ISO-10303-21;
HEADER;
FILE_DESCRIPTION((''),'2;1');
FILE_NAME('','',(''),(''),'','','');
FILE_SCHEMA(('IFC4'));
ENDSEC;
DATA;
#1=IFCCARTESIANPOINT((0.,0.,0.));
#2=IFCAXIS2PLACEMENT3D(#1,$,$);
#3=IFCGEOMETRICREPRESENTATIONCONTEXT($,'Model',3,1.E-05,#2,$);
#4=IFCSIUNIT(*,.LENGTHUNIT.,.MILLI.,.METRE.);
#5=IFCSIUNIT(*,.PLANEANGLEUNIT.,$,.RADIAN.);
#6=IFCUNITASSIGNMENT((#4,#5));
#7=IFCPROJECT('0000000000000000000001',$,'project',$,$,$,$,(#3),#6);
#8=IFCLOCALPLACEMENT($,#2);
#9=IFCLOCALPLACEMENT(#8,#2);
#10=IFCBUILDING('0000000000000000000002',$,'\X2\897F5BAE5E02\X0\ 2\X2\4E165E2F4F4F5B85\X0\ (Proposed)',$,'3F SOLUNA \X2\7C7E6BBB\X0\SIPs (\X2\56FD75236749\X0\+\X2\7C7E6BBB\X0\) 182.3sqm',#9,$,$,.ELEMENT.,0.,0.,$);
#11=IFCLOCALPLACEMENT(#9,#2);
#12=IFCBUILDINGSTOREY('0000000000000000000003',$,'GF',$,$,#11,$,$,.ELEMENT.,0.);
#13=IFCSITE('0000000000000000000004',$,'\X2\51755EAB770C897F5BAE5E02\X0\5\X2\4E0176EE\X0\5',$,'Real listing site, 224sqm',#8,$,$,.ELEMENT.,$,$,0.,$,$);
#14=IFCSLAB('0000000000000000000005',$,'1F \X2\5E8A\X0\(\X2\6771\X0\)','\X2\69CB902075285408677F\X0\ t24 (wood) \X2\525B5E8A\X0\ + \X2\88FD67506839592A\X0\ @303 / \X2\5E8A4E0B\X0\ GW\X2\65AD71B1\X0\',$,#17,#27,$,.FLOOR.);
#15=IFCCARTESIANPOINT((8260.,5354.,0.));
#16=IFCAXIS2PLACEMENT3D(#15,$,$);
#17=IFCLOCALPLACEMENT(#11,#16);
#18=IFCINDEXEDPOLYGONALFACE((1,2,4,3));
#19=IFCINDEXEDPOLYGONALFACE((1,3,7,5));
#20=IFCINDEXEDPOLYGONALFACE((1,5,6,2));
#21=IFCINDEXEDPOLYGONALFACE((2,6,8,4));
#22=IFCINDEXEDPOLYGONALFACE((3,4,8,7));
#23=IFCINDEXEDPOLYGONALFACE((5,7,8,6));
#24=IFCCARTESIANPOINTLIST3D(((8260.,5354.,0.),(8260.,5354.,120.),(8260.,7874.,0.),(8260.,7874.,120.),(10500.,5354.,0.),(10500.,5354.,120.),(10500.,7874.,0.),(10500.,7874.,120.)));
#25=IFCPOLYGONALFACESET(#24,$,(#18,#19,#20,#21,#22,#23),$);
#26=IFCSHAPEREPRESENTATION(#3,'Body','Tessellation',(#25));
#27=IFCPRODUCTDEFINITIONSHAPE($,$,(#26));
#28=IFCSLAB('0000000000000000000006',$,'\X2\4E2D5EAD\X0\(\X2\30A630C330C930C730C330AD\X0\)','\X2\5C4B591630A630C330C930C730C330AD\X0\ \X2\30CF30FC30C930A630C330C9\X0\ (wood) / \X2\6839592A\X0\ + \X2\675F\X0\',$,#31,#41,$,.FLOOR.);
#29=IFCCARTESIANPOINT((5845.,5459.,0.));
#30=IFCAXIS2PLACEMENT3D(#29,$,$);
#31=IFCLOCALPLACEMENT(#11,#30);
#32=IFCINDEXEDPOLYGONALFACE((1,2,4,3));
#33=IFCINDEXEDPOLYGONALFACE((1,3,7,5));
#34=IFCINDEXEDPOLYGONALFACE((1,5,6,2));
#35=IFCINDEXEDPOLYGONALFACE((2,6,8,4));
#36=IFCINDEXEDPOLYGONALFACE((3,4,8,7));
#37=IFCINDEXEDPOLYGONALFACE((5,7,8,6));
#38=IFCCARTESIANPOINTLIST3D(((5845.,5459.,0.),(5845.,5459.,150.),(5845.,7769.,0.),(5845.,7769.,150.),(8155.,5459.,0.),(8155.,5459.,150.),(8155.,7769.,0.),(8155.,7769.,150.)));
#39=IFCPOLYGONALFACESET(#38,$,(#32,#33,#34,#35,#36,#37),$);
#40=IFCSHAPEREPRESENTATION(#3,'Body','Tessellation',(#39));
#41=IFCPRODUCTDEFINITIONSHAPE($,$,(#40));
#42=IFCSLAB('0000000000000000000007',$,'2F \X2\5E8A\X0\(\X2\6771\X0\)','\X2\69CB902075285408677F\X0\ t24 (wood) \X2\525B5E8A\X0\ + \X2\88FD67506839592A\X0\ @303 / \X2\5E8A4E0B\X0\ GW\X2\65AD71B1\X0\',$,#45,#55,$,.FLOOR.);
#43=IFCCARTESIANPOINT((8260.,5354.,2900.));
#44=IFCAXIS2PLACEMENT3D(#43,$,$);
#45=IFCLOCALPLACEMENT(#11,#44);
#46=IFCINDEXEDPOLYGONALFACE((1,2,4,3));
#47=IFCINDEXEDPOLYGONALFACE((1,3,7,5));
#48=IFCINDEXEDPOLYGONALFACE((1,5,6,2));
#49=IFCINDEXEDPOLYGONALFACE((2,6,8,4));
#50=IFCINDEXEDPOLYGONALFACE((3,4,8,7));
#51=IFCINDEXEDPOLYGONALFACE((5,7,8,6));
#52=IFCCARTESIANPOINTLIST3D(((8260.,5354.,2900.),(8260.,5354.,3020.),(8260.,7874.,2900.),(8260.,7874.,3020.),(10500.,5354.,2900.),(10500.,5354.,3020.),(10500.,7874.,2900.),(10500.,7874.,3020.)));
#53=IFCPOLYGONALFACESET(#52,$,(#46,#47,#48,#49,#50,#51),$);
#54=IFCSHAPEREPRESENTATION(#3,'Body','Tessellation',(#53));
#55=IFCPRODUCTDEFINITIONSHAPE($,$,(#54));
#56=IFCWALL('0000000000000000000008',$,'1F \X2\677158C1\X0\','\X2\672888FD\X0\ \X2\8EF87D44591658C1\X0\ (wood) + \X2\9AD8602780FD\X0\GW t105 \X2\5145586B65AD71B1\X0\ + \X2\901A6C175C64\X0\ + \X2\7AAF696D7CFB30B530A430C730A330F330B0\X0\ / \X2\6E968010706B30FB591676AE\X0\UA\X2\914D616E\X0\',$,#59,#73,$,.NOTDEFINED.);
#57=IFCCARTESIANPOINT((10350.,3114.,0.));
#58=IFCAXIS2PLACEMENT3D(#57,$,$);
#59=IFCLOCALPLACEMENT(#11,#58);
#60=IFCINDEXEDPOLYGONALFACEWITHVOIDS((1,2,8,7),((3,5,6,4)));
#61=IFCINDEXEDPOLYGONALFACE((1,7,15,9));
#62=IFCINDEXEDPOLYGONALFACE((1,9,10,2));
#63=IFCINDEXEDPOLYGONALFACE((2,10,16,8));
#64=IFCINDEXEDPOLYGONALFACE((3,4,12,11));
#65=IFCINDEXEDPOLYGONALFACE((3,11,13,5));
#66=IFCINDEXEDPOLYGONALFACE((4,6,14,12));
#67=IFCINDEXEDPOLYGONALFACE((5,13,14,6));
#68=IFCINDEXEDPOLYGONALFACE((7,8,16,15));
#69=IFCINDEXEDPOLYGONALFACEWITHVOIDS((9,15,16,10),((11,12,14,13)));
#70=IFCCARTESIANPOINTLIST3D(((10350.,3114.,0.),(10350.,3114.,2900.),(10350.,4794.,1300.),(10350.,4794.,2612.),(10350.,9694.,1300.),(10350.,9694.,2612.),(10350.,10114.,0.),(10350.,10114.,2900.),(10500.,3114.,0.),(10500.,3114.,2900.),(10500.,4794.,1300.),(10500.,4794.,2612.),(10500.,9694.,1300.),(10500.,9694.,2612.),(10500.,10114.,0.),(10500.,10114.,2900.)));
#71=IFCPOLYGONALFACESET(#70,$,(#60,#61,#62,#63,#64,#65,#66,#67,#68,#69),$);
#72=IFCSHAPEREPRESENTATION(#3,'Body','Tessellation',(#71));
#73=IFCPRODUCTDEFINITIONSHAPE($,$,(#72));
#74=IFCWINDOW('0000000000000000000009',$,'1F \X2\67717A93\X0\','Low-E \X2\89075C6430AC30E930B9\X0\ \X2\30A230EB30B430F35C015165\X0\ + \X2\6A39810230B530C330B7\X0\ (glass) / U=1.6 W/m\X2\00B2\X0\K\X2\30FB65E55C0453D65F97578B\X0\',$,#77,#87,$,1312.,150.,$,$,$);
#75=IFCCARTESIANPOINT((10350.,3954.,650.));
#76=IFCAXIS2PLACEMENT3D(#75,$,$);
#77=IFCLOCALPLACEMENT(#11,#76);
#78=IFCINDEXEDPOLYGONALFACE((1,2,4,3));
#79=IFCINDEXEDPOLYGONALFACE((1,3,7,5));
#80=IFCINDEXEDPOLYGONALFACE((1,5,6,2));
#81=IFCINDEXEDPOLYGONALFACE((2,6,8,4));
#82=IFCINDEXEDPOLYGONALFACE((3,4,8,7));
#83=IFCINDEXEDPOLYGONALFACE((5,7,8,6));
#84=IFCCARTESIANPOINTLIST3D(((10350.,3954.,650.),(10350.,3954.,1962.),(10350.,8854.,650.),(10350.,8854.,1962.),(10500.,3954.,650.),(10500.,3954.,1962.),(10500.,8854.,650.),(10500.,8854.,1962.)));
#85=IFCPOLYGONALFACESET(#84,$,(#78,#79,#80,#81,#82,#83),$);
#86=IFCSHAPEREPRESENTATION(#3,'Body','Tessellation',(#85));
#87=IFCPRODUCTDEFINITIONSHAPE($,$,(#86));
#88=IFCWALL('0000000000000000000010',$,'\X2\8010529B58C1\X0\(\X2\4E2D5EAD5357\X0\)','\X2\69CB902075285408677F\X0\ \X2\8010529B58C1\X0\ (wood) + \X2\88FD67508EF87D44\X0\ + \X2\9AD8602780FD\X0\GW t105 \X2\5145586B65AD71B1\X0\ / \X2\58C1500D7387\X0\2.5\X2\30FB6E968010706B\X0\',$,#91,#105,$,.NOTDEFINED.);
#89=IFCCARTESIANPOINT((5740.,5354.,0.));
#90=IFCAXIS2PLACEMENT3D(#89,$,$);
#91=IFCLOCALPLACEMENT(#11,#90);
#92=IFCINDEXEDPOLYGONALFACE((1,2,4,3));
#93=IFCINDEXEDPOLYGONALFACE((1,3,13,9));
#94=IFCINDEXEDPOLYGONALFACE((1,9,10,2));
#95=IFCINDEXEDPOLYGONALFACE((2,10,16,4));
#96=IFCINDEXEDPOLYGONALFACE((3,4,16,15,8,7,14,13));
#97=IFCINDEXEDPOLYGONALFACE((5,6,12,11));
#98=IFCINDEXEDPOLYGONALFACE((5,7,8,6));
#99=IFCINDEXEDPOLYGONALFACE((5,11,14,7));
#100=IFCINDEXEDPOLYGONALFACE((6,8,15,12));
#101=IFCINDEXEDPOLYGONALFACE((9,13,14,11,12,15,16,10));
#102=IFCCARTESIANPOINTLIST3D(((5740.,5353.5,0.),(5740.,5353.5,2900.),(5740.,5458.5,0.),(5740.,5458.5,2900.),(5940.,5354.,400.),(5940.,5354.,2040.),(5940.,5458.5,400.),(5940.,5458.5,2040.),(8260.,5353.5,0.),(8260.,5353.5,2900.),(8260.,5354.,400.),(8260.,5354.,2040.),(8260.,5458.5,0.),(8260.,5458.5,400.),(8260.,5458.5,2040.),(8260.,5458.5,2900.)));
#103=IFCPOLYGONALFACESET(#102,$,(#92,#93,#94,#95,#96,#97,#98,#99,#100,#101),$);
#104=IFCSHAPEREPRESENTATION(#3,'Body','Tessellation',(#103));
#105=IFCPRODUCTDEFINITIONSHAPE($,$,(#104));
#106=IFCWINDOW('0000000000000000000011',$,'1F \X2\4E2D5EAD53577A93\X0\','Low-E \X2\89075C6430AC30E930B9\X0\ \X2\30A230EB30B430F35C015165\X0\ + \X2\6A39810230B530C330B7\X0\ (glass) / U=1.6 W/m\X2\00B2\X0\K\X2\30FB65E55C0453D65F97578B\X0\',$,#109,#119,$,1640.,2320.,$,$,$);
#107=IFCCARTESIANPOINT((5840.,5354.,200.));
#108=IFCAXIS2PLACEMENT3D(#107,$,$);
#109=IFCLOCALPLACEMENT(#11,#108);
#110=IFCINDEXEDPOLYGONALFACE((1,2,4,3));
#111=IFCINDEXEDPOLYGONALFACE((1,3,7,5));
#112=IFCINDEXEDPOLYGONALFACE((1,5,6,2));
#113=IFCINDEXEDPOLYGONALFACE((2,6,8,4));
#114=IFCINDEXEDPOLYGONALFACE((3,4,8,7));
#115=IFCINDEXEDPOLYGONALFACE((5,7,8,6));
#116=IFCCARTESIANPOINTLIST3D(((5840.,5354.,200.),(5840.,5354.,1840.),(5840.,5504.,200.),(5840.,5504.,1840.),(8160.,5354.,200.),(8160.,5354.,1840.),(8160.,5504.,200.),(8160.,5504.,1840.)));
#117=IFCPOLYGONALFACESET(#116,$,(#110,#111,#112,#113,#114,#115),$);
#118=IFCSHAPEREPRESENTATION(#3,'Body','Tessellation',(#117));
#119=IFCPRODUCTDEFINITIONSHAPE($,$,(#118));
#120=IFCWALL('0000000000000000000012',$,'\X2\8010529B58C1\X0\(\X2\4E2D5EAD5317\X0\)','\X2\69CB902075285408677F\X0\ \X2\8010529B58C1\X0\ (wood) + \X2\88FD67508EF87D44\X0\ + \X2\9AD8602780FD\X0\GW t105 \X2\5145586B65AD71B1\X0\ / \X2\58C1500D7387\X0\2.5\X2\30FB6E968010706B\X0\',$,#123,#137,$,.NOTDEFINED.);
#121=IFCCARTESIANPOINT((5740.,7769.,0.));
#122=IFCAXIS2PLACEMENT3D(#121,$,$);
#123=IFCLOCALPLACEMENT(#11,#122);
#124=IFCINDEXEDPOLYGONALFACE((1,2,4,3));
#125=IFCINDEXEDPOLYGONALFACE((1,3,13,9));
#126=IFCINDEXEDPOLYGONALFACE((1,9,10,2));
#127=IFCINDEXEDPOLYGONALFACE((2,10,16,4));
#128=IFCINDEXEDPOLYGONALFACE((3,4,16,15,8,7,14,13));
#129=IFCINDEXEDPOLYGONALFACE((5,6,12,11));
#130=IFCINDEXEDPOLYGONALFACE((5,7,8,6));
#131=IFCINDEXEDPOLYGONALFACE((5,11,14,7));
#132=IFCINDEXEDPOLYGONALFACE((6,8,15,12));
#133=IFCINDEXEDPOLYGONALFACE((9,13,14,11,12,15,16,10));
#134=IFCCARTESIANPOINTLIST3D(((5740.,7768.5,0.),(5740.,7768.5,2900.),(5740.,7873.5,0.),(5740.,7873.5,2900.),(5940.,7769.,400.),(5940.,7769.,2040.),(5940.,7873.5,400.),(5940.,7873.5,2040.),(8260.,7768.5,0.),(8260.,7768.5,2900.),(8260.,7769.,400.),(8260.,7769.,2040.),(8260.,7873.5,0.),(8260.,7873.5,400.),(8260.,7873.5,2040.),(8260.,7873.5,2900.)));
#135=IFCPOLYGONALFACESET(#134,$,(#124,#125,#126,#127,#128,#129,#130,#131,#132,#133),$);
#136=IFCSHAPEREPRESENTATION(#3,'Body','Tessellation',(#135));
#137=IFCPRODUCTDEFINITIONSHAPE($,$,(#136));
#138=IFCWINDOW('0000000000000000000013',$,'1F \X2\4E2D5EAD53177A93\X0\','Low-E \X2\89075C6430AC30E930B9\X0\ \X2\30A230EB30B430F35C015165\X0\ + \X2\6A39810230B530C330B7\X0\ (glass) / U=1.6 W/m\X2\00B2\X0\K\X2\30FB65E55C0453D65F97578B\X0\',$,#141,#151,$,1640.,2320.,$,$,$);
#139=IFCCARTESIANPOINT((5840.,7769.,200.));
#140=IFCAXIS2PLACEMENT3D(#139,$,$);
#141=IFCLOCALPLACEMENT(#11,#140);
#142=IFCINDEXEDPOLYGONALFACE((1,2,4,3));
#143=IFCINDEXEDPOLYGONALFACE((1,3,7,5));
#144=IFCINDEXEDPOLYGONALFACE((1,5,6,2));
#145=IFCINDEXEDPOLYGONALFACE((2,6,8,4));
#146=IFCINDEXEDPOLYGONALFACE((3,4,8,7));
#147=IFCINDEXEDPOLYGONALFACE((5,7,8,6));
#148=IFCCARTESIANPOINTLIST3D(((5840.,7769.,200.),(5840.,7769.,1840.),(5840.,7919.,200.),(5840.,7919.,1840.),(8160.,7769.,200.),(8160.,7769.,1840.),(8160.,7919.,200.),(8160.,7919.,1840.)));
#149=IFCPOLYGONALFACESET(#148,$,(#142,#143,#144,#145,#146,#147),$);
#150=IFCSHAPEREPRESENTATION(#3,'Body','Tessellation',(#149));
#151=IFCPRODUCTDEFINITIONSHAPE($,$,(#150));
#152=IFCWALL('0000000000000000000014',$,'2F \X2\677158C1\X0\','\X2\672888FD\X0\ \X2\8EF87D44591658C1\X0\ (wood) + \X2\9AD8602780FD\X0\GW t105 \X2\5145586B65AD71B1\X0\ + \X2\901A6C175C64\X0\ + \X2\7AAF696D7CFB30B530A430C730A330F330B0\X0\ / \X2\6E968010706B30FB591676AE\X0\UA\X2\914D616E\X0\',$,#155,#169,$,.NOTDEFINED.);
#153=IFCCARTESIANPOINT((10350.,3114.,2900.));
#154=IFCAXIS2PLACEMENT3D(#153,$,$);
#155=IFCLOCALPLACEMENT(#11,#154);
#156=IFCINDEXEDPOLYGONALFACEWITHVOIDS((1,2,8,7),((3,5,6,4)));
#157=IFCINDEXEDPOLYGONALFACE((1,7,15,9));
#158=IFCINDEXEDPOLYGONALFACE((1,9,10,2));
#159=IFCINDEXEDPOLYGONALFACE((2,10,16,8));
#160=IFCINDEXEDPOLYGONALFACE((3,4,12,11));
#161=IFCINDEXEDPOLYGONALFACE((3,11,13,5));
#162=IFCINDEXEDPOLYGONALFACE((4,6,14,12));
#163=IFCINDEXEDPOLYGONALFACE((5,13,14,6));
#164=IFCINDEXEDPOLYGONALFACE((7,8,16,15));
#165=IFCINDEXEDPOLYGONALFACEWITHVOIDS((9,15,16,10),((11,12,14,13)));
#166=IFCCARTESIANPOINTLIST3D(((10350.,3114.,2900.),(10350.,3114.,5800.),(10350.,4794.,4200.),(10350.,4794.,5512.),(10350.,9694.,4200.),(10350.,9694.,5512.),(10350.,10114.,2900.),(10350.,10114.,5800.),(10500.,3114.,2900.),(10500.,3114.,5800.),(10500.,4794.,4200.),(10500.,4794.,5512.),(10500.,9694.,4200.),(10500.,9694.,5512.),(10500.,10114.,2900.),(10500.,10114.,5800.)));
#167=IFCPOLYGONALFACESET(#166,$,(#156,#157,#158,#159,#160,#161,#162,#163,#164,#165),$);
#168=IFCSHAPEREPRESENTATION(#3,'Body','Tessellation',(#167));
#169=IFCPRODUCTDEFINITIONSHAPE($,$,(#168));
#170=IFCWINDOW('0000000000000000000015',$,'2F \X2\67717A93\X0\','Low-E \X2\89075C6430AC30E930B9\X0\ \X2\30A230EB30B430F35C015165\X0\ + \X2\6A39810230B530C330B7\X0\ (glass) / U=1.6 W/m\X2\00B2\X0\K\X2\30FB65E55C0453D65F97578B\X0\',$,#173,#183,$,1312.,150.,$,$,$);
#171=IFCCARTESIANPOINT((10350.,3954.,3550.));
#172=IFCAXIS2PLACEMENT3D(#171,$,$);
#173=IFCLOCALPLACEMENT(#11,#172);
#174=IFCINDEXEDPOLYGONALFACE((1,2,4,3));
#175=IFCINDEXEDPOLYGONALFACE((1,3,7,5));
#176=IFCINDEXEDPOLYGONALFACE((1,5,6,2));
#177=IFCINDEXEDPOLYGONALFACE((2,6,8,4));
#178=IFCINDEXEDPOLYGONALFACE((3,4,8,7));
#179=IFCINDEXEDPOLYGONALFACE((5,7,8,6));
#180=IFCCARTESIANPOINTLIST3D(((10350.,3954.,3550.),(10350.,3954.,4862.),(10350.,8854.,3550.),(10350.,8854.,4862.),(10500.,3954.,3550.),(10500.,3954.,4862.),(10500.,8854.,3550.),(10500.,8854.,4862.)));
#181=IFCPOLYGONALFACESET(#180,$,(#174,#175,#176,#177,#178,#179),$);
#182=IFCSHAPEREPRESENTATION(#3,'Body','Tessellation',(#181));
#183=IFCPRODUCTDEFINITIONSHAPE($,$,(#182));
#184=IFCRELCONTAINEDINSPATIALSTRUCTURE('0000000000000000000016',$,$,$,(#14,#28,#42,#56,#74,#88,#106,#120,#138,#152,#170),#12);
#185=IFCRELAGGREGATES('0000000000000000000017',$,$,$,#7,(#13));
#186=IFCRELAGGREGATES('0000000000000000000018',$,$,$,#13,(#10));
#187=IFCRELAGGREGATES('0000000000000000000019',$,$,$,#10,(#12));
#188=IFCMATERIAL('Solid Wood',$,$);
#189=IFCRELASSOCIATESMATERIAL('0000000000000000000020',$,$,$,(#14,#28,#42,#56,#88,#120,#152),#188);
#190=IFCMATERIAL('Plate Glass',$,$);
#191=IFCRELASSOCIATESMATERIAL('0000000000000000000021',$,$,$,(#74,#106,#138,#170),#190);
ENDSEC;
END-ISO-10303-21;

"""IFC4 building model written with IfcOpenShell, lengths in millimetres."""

from ifc_helpers import new_model, si_unit, frame, frame_2d, origin, place, context, project, spatial, rectangle, extrude, material, element, fill, save


model = new_model("IFC4")

# Units and contexts
model_context = context("Model", 3, precision=1e-05, world=origin())
ifc_project = project(units=[si_unit("LENGTHUNIT", "METRE", prefix="MILLI"), si_unit("PLANEANGLEUNIT", "RADIAN")], contexts=[model_context])

# Site, building, storey
site_placement = place(None, origin())
site = spatial("IfcSite", under=ifc_project, at=site_placement, Name="兵庫県西宮市5丁目5", ObjectType="Real listing site, 224sqm", CompositionType="ELEMENT", RefElevation=0.0)
building_placement = place(site_placement, origin())
building = spatial("IfcBuilding", under=site, at=building_placement, Name="西宮市 2世帯住宅 (Proposed)", ObjectType="3F SOLUNA 籾殻SIPs (国産杉+籾殻) 182.3sqm", CompositionType="ELEMENT", ElevationOfRefHeight=0.0, ElevationOfTerrain=0.0)
storey_placement = place(building_placement, origin())
storey = spatial("IfcBuildingStorey", under=building, at=storey_placement, Name="GF", CompositionType="ELEMENT", Elevation=0.0)

# Slabs
ifc_material_1 = material(Name="Solid Wood")
slab_1_placement = place(storey_placement, frame((8260.0, 5354.0, 0.0)))
element("IfcSlab", 1, at=slab_1_placement, inside=storey, material=ifc_material_1, Name="1F 床(東)", Description="構造用合板 t24 (wood) 剛床 + 製材根太 @303 / 床下 GW断熱", PredefinedType="FLOOR", context=model_context, shape_type="SweptSolid", body=[
    extrude(rectangle(XDim=2240.0, YDim=2520.0, at=frame_2d((1120.0, 1260.0))), frame((8260.0, 5354.0, 0.0)), (0.0, 0.0, 1.0), 120.0),
])
slab_2_placement = place(storey_placement, frame((5845.0, 5459.0, 0.0)))
element("IfcSlab", 2, at=slab_2_placement, inside=storey, material=ifc_material_1, Name="中庭(ウッドデッキ)", Description="屋外ウッドデッキ ハードウッド (wood) / 根太 + 束", PredefinedType="FLOOR", context=model_context, shape_type="SweptSolid", body=[
    extrude(rectangle(XDim=2310.0, YDim=2310.0, at=frame_2d((1155.0, 1155.0))), frame((5845.0, 5459.0, 0.0)), (0.0, 0.0, 1.0), 150.0),
])
slab_3_placement = place(storey_placement, frame((8260.0, 5354.0, 2900.0)))
element("IfcSlab", 3, at=slab_3_placement, inside=storey, material=ifc_material_1, Name="2F 床(東)", Description="構造用合板 t24 (wood) 剛床 + 製材根太 @303 / 床下 GW断熱", PredefinedType="FLOOR", context=model_context, shape_type="SweptSolid", body=[
    extrude(rectangle(XDim=2240.0, YDim=2520.0, at=frame_2d((1120.0, 1260.0))), frame((8260.0, 5354.0, 2900.0)), (0.0, 0.0, 1.0), 120.0),
])

# Walls, openings, windows
wall_1_placement = place(storey_placement, frame((10350.0, 3114.0, 0.0)))
wall_1 = element("IfcWall", 4, at=wall_1_placement, inside=storey, material=ifc_material_1, Name="1F 東壁", Description="木製 軸組外壁 (wood) + 高性能GW t105 充填断熱 + 通気層 + 窯業系サイディング / 準耐火・外皮UA配慮", PredefinedType="NOTDEFINED", context=model_context, shape_type="SweptSolid", body=[
    extrude(rectangle(XDim=150.0, YDim=7000.0, at=frame_2d((75.0, 3500.0))), frame((10350.0, 3114.0, 0.0)), (0.0, 0.0, 1.0), 2900.0),
])
opening_1_placement = place(storey_placement, frame((10350.0, 3954.0, 650.0)))
opening_1 = element("IfcOpeningElement", 5, at=opening_1_placement, cuts=wall_1, PredefinedType="NOTDEFINED", context=model_context, shape_type="SweptSolid", body=[
    extrude(rectangle(XDim=150.0, YDim=4900.0, at=frame_2d((75.0, 2450.0))), frame((10350.0, 3954.0, 650.0)), (0.0, 0.0, 1.0), 1312.0),
])
ifc_material_2 = material(Name="Plate Glass")
window_1_placement = place(storey_placement, frame((10350.0, 3954.0, 650.0)))
window_1 = element("IfcWindow", 6, at=window_1_placement, inside=storey, material=ifc_material_2, Name="1F 東窓", Description="Low-E 複層ガラス アルゴン封入 + 樹脂サッシ (glass) / U=1.6 W/m²K・日射取得型", OverallHeight=1312.0, OverallWidth=150.0, context=model_context, shape_type="SweptSolid", body=[
    extrude(rectangle(XDim=150.0, YDim=4900.0, at=frame_2d((75.0, 2450.0))), frame((10350.0, 3954.0, 650.0)), (0.0, 0.0, 1.0), 1312.0),
])
fill(opening_1, window_1)
wall_2_placement = place(storey_placement, frame((5740.0, 5354.0, 0.0)))
wall_2 = element("IfcWall", 7, at=wall_2_placement, inside=storey, material=ifc_material_1, Name="耐力壁(中庭南)", Description="構造用合板 耐力壁 (wood) + 製材軸組 + 高性能GW t105 充填断熱 / 壁倍率2.5・準耐火", PredefinedType="NOTDEFINED", context=model_context, shape_type="SweptSolid", body=[
    extrude(rectangle(XDim=2520.0, YDim=105.0, at=frame_2d((1260.0, 52.0))), frame((5740.0, 5354.0, 0.0)), (0.0, 0.0, 1.0), 2900.0),
])
opening_2_placement = place(storey_placement, frame((5840.0, 5354.0, 200.0)))
opening_2 = element("IfcOpeningElement", 8, at=opening_2_placement, cuts=wall_2, PredefinedType="NOTDEFINED", context=model_context, shape_type="SweptSolid", body=[
    extrude(rectangle(XDim=2320.0, YDim=150.0, at=frame_2d((1160.0, 75.0))), frame((5840.0, 5354.0, 200.0)), (0.0, 0.0, 1.0), 1640.0),
])
window_2_placement = place(storey_placement, frame((5840.0, 5354.0, 200.0)))
window_2 = element("IfcWindow", 9, at=window_2_placement, inside=storey, material=ifc_material_2, Name="1F 中庭南窓", Description="Low-E 複層ガラス アルゴン封入 + 樹脂サッシ (glass) / U=1.6 W/m²K・日射取得型", OverallHeight=1640.0, OverallWidth=2320.0, context=model_context, shape_type="SweptSolid", body=[
    extrude(rectangle(XDim=2320.0, YDim=150.0, at=frame_2d((1160.0, 75.0))), frame((5840.0, 5354.0, 200.0)), (0.0, 0.0, 1.0), 1640.0),
])
fill(opening_2, window_2)
wall_3_placement = place(storey_placement, frame((5740.0, 7769.0, 0.0)))
wall_3 = element("IfcWall", 10, at=wall_3_placement, inside=storey, material=ifc_material_1, Name="耐力壁(中庭北)", Description="構造用合板 耐力壁 (wood) + 製材軸組 + 高性能GW t105 充填断熱 / 壁倍率2.5・準耐火", PredefinedType="NOTDEFINED", context=model_context, shape_type="SweptSolid", body=[
    extrude(rectangle(XDim=2520.0, YDim=105.0, at=frame_2d((1260.0, 52.0))), frame((5740.0, 7769.0, 0.0)), (0.0, 0.0, 1.0), 2900.0),
])
opening_3_placement = place(storey_placement, frame((5840.0, 7769.0, 200.0)))
opening_3 = element("IfcOpeningElement", 11, at=opening_3_placement, cuts=wall_3, PredefinedType="NOTDEFINED", context=model_context, shape_type="SweptSolid", body=[
    extrude(rectangle(XDim=2320.0, YDim=150.0, at=frame_2d((1160.0, 75.0))), frame((5840.0, 7769.0, 200.0)), (0.0, 0.0, 1.0), 1640.0),
])
window_3_placement = place(storey_placement, frame((5840.0, 7769.0, 200.0)))
window_3 = element("IfcWindow", 12, at=window_3_placement, inside=storey, material=ifc_material_2, Name="1F 中庭北窓", Description="Low-E 複層ガラス アルゴン封入 + 樹脂サッシ (glass) / U=1.6 W/m²K・日射取得型", OverallHeight=1640.0, OverallWidth=2320.0, context=model_context, shape_type="SweptSolid", body=[
    extrude(rectangle(XDim=2320.0, YDim=150.0, at=frame_2d((1160.0, 75.0))), frame((5840.0, 7769.0, 200.0)), (0.0, 0.0, 1.0), 1640.0),
])
fill(opening_3, window_3)

# Wall, opening, window
wall_4_placement = place(storey_placement, frame((10350.0, 3114.0, 2900.0)))
wall_4 = element("IfcWall", 13, at=wall_4_placement, inside=storey, material=ifc_material_1, Name="2F 東壁", Description="木製 軸組外壁 (wood) + 高性能GW t105 充填断熱 + 通気層 + 窯業系サイディング / 準耐火・外皮UA配慮", PredefinedType="NOTDEFINED", context=model_context, shape_type="SweptSolid", body=[
    extrude(rectangle(XDim=150.0, YDim=7000.0, at=frame_2d((75.0, 3500.0))), frame((10350.0, 3114.0, 2900.0)), (0.0, 0.0, 1.0), 2900.0),
])
opening_4_placement = place(storey_placement, frame((10350.0, 3954.0, 3550.0)))
opening_4 = element("IfcOpeningElement", 14, at=opening_4_placement, cuts=wall_4, PredefinedType="NOTDEFINED", context=model_context, shape_type="SweptSolid", body=[
    extrude(rectangle(XDim=150.0, YDim=4900.0, at=frame_2d((75.0, 2450.0))), frame((10350.0, 3954.0, 3550.0)), (0.0, 0.0, 1.0), 1312.0),
])
window_4_placement = place(storey_placement, frame((10350.0, 3954.0, 3550.0)))
window_4 = element("IfcWindow", 15, at=window_4_placement, inside=storey, material=ifc_material_2, Name="2F 東窓", Description="Low-E 複層ガラス アルゴン封入 + 樹脂サッシ (glass) / U=1.6 W/m²K・日射取得型", OverallHeight=1312.0, OverallWidth=150.0, context=model_context, shape_type="SweptSolid", body=[
    extrude(rectangle(XDim=150.0, YDim=4900.0, at=frame_2d((75.0, 2450.0))), frame((10350.0, 3954.0, 3550.0)), (0.0, 0.0, 1.0), 1312.0),
])
fill(opening_4, window_4)

save(model, "model.ifc")
